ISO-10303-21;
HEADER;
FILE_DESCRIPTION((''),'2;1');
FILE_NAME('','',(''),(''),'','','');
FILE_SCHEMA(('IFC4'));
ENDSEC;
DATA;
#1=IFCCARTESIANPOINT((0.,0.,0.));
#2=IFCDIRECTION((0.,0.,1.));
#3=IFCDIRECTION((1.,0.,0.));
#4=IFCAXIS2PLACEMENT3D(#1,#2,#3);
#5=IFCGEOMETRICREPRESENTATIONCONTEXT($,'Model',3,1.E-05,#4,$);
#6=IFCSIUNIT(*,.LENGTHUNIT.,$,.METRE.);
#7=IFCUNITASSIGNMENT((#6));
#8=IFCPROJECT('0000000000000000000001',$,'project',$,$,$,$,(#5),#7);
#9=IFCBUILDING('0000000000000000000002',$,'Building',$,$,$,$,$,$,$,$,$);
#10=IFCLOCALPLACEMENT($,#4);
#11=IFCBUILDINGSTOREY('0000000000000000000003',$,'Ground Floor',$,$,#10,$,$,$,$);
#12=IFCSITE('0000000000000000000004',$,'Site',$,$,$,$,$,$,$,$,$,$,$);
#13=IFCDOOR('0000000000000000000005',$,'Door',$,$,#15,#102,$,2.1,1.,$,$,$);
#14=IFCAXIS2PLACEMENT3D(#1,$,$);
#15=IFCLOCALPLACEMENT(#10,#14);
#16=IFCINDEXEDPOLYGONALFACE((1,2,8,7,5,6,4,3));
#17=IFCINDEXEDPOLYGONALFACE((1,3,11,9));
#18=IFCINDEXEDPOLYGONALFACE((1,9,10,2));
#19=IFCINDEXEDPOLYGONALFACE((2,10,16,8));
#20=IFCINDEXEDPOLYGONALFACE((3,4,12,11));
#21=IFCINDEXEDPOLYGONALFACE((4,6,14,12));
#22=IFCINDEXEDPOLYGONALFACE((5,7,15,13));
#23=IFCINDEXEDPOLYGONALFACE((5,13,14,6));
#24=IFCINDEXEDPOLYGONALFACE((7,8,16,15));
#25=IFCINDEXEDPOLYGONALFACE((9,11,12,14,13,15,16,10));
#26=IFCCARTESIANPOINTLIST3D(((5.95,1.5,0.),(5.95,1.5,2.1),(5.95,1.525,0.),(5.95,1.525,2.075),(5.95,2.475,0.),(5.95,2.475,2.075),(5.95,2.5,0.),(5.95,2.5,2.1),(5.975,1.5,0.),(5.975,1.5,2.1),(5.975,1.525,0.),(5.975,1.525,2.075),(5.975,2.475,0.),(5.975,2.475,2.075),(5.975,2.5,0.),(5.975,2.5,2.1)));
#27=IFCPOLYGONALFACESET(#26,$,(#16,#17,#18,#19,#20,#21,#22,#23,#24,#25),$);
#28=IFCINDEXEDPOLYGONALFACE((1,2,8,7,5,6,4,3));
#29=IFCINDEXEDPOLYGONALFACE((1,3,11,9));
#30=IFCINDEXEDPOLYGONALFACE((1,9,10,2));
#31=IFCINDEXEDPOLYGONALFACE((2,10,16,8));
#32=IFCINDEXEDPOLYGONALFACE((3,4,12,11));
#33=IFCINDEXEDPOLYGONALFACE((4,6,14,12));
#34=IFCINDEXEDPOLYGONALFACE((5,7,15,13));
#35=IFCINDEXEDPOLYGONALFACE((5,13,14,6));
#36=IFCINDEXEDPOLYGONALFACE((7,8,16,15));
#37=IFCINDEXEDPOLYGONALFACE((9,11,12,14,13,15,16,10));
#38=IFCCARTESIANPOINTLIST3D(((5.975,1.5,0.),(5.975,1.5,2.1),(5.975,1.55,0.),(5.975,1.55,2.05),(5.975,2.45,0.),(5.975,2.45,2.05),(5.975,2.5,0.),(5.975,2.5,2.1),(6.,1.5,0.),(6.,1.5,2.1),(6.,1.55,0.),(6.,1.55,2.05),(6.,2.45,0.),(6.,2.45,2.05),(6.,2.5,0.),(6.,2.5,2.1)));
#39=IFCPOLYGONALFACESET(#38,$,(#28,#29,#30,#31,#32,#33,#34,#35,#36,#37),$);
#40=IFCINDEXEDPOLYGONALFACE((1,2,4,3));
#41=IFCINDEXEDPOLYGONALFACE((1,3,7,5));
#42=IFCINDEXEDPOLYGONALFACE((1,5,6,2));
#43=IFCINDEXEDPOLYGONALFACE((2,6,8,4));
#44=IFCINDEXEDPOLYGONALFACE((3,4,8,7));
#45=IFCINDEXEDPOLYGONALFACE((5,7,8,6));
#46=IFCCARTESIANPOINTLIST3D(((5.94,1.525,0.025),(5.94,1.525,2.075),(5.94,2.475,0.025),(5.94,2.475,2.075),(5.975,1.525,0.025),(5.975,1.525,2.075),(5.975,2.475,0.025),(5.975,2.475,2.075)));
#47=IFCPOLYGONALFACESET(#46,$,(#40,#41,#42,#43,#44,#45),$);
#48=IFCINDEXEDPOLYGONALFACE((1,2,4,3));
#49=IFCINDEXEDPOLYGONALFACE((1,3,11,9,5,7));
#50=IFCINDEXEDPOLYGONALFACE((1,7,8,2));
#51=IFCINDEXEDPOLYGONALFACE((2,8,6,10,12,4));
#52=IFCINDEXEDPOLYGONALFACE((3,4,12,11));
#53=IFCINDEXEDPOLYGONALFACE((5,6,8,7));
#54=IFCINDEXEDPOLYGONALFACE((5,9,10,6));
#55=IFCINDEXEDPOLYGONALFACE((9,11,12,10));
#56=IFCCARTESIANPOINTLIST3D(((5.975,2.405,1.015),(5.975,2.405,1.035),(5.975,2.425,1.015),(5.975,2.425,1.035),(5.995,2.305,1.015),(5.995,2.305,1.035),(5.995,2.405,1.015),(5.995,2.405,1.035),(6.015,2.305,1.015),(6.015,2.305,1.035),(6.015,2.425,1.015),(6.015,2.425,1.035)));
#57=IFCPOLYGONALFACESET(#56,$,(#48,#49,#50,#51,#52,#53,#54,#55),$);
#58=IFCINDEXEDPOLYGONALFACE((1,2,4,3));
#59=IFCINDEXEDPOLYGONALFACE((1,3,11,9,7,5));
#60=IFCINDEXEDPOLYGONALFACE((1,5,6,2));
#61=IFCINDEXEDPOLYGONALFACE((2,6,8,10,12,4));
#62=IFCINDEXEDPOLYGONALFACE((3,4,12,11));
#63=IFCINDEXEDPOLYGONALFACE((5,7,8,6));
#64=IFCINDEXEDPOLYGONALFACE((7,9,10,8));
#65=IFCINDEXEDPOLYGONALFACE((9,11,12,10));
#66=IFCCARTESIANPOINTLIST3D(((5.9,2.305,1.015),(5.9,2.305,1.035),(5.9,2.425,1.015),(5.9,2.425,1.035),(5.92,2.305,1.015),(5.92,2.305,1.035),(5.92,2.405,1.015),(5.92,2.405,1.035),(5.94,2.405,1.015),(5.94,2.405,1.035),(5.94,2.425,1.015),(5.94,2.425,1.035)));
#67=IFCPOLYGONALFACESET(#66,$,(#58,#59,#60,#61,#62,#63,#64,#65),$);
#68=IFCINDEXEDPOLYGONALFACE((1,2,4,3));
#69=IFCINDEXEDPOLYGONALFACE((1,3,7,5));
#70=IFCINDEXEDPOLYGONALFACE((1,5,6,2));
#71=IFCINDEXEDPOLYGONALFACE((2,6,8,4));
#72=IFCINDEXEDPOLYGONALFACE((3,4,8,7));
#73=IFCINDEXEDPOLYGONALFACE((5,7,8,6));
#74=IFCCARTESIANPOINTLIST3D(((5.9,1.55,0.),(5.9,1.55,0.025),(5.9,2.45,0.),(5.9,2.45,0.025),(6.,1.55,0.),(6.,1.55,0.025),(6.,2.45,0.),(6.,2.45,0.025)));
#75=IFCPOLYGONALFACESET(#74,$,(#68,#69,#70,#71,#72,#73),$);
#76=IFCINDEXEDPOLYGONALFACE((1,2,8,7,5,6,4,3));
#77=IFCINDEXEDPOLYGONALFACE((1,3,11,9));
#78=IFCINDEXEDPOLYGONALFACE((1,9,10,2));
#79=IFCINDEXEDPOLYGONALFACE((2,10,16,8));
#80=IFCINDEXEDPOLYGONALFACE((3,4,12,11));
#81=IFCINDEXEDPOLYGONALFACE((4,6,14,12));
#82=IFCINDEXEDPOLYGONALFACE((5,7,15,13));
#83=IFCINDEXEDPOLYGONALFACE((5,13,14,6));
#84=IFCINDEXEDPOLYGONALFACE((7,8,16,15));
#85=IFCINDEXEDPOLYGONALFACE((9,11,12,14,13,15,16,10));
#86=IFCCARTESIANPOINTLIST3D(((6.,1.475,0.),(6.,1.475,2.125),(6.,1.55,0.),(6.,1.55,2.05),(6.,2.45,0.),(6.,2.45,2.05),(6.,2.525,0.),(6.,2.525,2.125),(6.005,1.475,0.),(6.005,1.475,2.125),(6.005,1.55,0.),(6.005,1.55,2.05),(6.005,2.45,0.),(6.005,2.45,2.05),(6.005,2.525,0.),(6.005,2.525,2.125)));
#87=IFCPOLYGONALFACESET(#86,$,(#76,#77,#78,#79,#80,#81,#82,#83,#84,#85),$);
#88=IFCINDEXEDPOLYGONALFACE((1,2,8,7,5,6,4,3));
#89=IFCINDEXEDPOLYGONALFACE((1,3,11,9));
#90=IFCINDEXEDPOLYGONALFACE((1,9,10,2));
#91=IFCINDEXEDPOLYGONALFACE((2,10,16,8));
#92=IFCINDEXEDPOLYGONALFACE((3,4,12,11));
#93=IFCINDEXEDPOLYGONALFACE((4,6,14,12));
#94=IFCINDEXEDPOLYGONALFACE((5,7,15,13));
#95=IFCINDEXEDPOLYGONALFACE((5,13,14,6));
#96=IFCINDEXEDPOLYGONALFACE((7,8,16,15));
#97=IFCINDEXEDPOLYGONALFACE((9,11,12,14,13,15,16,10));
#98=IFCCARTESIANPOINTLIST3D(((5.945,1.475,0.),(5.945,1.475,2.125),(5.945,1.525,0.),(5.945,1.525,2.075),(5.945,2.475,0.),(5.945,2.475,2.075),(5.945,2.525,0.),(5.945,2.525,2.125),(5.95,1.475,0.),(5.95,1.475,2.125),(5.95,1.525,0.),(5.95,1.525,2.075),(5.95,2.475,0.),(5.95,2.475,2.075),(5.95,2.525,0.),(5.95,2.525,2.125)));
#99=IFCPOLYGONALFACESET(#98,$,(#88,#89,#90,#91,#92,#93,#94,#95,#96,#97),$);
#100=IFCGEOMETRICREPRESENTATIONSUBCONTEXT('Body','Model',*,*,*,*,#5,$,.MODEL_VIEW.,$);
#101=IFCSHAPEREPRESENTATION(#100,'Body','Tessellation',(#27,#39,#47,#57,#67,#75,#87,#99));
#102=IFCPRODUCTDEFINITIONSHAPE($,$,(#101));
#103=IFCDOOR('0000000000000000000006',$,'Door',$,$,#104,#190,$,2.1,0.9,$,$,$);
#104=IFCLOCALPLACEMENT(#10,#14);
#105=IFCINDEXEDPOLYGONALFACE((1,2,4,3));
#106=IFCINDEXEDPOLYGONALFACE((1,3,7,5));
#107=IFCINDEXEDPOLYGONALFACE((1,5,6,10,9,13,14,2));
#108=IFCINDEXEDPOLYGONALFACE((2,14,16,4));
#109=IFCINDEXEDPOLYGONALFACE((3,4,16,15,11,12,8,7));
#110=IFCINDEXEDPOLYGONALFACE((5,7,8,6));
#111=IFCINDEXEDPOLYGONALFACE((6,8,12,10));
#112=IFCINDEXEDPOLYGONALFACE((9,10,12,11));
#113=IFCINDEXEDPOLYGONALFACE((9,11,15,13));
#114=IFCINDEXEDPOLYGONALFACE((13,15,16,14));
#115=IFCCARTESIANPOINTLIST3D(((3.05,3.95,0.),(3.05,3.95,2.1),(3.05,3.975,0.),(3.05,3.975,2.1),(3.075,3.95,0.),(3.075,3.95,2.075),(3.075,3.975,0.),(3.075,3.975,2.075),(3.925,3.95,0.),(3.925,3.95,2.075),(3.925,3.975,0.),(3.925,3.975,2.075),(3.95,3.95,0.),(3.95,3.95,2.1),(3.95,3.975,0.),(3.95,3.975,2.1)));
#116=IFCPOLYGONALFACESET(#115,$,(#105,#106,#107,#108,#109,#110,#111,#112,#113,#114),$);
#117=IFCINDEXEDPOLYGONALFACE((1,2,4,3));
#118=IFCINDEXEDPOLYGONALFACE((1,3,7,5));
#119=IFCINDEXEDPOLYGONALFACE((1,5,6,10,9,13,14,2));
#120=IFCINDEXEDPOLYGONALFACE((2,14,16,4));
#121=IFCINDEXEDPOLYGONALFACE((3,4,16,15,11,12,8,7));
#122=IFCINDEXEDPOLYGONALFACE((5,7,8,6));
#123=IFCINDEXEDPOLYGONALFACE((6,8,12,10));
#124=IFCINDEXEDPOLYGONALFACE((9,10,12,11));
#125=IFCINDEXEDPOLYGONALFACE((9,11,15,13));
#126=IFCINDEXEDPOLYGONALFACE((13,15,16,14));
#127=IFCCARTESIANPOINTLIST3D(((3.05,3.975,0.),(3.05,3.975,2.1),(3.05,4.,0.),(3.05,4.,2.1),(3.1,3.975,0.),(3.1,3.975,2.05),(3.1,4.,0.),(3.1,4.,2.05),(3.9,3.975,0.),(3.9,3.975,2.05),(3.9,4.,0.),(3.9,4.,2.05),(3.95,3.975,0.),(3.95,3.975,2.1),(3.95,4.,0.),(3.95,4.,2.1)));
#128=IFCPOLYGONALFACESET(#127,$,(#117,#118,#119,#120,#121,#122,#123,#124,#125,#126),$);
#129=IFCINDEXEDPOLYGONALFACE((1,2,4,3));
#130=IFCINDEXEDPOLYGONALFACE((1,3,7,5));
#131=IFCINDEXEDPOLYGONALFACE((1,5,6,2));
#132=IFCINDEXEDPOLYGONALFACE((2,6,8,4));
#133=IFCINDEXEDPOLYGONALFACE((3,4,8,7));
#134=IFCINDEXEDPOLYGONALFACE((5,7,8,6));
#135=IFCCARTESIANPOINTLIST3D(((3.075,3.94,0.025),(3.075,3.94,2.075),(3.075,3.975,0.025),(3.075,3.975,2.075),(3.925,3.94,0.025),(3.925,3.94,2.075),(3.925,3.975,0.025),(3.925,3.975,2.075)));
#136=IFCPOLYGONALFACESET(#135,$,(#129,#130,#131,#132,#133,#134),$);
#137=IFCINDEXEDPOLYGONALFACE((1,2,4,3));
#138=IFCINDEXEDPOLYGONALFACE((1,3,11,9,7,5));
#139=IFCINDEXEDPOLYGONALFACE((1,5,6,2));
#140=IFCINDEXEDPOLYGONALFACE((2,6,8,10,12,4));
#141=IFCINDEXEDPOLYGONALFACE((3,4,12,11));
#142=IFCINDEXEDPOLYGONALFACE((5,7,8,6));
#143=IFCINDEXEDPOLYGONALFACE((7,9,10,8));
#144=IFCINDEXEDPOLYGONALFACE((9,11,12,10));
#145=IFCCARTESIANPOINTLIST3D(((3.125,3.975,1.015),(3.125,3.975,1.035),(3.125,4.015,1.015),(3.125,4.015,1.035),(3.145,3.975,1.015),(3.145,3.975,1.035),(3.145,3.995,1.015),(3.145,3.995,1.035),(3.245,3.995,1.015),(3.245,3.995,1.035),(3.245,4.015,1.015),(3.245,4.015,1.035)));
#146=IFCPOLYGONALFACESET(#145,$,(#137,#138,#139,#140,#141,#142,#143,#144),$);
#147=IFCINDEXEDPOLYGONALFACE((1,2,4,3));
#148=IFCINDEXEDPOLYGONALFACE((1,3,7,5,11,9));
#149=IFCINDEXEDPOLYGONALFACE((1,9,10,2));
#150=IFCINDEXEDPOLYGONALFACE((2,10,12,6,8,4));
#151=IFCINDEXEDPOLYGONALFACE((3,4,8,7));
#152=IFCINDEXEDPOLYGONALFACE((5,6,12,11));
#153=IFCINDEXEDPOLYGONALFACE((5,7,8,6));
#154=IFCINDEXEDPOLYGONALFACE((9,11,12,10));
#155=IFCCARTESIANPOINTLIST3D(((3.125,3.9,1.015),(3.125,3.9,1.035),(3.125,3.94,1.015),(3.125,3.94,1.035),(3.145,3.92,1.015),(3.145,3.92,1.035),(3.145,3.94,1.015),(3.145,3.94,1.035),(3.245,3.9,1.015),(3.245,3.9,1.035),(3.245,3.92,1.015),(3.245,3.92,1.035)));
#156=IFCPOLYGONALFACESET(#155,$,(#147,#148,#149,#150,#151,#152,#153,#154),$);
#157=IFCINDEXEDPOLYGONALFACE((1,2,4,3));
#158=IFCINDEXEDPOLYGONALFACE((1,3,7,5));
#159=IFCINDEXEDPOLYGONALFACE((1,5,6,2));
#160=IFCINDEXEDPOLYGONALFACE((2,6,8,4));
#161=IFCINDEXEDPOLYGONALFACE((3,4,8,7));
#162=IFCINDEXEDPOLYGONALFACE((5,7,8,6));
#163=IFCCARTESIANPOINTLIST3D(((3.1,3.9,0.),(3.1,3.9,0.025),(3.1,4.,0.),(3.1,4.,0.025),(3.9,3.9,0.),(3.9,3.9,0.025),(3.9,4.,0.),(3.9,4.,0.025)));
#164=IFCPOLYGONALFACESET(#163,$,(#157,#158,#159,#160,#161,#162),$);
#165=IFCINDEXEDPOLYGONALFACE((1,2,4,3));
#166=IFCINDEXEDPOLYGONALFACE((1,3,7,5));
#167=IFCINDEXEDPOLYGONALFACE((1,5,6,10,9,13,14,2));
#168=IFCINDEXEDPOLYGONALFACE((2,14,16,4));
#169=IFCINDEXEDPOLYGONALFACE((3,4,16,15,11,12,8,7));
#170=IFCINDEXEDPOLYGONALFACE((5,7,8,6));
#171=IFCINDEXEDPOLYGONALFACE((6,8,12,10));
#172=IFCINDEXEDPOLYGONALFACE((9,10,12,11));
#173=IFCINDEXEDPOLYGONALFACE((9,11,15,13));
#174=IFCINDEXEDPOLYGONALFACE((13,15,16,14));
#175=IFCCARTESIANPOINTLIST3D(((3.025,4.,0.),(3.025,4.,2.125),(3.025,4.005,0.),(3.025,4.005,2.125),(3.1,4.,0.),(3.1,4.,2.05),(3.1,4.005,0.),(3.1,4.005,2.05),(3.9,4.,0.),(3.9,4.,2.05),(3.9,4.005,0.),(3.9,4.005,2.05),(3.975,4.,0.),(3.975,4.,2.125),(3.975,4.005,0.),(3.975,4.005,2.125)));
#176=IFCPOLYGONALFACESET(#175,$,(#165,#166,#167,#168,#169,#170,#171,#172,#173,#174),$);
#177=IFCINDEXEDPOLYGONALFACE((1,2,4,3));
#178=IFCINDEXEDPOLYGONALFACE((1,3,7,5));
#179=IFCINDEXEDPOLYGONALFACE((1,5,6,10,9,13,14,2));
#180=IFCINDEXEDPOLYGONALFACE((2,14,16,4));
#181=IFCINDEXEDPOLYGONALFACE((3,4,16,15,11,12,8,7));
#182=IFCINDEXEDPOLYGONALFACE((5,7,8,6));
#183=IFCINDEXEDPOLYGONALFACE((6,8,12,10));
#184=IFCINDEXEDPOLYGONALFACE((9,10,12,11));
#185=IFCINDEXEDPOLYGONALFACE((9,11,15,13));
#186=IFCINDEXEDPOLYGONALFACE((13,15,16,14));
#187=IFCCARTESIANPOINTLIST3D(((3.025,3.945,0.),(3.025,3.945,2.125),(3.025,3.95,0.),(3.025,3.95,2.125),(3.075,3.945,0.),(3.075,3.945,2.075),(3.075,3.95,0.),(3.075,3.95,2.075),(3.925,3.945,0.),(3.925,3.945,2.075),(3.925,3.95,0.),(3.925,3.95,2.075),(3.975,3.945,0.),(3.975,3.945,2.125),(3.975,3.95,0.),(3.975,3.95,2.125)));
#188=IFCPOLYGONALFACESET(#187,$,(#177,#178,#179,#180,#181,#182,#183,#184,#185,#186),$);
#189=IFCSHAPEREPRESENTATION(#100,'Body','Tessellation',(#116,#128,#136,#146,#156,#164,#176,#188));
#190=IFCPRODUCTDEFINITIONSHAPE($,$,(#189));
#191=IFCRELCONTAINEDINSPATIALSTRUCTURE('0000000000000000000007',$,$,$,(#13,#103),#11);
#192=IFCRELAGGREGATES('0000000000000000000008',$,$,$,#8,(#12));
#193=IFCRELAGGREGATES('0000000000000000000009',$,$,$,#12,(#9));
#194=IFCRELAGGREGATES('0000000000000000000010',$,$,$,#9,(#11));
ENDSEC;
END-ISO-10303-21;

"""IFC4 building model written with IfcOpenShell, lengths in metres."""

from ifc_helpers import new_model, si_unit, frame, origin_with_axes, place, context, subcontext, project, spatial, line, indexed_curve, outline, extrude, element, save


model = new_model("IFC4")

# Units and contexts
model_context = context("Model", 3, precision=1e-05, world=origin_with_axes())
body_context = subcontext(model_context, "Body", "Model", "MODEL_VIEW")
ifc_project = project(units=[si_unit("LENGTHUNIT", "METRE")], contexts=[model_context])

# Site, building, storey
site = spatial("IfcSite", under=ifc_project, Name="Site")
building = spatial("IfcBuilding", under=site, Name="Building")
storey_placement = place(None, origin_with_axes())
storey = spatial("IfcBuildingStorey", under=building, at=storey_placement, Name="Ground Floor")

# Doors
door_1_placement = place(storey_placement, frame((6.0, 1.5, 0.0), z_axis=(0.0, 0.0, 1.0), x_axis=(0.0, 1.0, 0.0)))
element("IfcDoor", 1, at=door_1_placement, inside=storey, Name="Door", OverallHeight=2.1, OverallWidth=1.0, context=body_context, shape_type="SweptSolid", body=[
    extrude(outline(indexed_curve([(0.0, 0.0), (0.0, 2.1), (1.0, 2.1), (1.0, 0.0), (0.975, 0.0), (0.975, 2.075), (0.025, 2.075), (0.025, 0.0)], segments=[line(1, 2, 3, 4, 5, 6, 7, 8, 1)])), frame((0.0, 0.025, 0.0), z_axis=(0.0, -1.0, 0.0), x_axis=(1.0, 0.0, 0.0)), (0.0, 0.0, -1.0), 0.025),
    extrude(outline(indexed_curve([(0.0, 0.0), (0.0, 2.1), (1.0, 2.1), (1.0, 0.0), (0.95, 0.0), (0.95, 2.05), (0.05, 2.05), (0.05, 0.0)], segments=[line(1, 2, 3, 4, 5, 6, 7, 8, 1)])), frame((0.0, 0.0, 0.0), z_axis=(0.0, -1.0, 0.0), x_axis=(1.0, 0.0, 0.0)), (0.0, 0.0, -1.0), 0.025),
    extrude(outline(indexed_curve([(0.0, 0.0), (0.95, 0.0), (0.95, 0.035), (0.0, 0.035)], segments=[line(1, 2, 3, 4, 1)])), frame((0.025, 0.025, 0.025), z_axis=(0.0, 0.0, 1.0), x_axis=(1.0, 0.0, 0.0)), (0.0, 0.0, 1.0), 2.05),
    extrude(outline(indexed_curve([(0.0, 0.0), (0.0, -0.04), (-0.12, -0.04), (-0.12, -0.02), (-0.02, -0.02), (-0.02, 0.0)], segments=[line(1, 2, 3, 4, 5, 6, 1)])), frame((0.925, 0.025, 1.015), z_axis=(0.0, 0.0, 1.0), x_axis=(1.0, 0.0, 0.0)), (0.0, 0.0, 1.0), 0.02),
    extrude(outline(indexed_curve([(0.0, 0.0), (0.0, 0.04), (-0.12, 0.04), (-0.12, 0.02), (-0.02, 0.02), (-0.02, 0.0)], segments=[line(1, 2, 3, 4, 5, 6, 1)])), frame((0.925, 0.06, 1.015), z_axis=(0.0, 0.0, 1.0), x_axis=(1.0, 0.0, 0.0)), (0.0, 0.0, 1.0), 0.02),
    extrude(outline(indexed_curve([(0.0, 0.0), (0.9, 0.0), (0.9, 0.1), (0.0, 0.1)], segments=[line(1, 2, 3, 4, 1)])), frame((0.05, 0.0, 0.0), z_axis=(0.0, 0.0, 1.0), x_axis=(1.0, 0.0, 0.0)), (0.0, 0.0, 1.0), 0.025),
    extrude(outline(indexed_curve([(0.0, 0.0), (0.0, 2.125), (1.05, 2.125), (1.05, 0.0), (0.975, 0.0), (0.975, 2.05), (0.075, 2.05), (0.075, 0.0)], segments=[line(1, 2, 3, 4, 5, 6, 7, 8, 1)])), frame((-0.025, -0.005, 0.0), z_axis=(0.0, -1.0, 0.0), x_axis=(1.0, 0.0, 0.0)), (0.0, 0.0, -1.0), 0.005),
    extrude(outline(indexed_curve([(0.0, 0.0), (0.0, 2.125), (1.05, 2.125), (1.05, 0.0), (1.0, 0.0), (1.0, 2.075), (0.05, 2.075), (0.05, 0.0)], segments=[line(1, 2, 3, 4, 5, 6, 7, 8, 1)])), frame((-0.025, 0.05, 0.0), z_axis=(0.0, -1.0, 0.0), x_axis=(1.0, 0.0, 0.0)), (0.0, 0.0, -1.0), 0.005),
])
door_2_placement = place(storey_placement, frame((3.95, 4.0, 0.0), z_axis=(0.0, 0.0, 1.0), x_axis=(-1.0, 0.0, 0.0)))
element("IfcDoor", 2, at=door_2_placement, inside=storey, Name="Door", OverallHeight=2.1, OverallWidth=0.9, context=body_context, shape_type="SweptSolid", body=[
    extrude(outline(indexed_curve([(0.0, 0.0), (0.0, 2.1), (0.9, 2.1), (0.9, 0.0), (0.875, 0.0), (0.875, 2.075), (0.025, 2.075), (0.025, 0.0)], segments=[line(1, 2, 3, 4, 5, 6, 7, 8, 1)])), frame((0.0, 0.025, 0.0), z_axis=(0.0, -1.0, 0.0), x_axis=(1.0, 0.0, 0.0)), (0.0, 0.0, -1.0), 0.025),
    extrude(outline(indexed_curve([(0.0, 0.0), (0.0, 2.1), (0.9, 2.1), (0.9, 0.0), (0.85, 0.0), (0.85, 2.05), (0.05, 2.05), (0.05, 0.0)], segments=[line(1, 2, 3, 4, 5, 6, 7, 8, 1)])), frame((0.0, 0.0, 0.0), z_axis=(0.0, -1.0, 0.0), x_axis=(1.0, 0.0, 0.0)), (0.0, 0.0, -1.0), 0.025),
    extrude(outline(indexed_curve([(0.0, 0.0), (0.85, 0.0), (0.85, 0.035), (0.0, 0.035)], segments=[line(1, 2, 3, 4, 1)])), frame((0.025, 0.025, 0.025), z_axis=(0.0, 0.0, 1.0), x_axis=(1.0, 0.0, 0.0)), (0.0, 0.0, 1.0), 2.05),
    extrude(outline(indexed_curve([(0.0, 0.0), (0.0, -0.04), (-0.12, -0.04), (-0.12, -0.02), (-0.02, -0.02), (-0.02, 0.0)], segments=[line(1, 2, 3, 4, 5, 6, 1)])), frame((0.825, 0.025, 1.015), z_axis=(0.0, 0.0, 1.0), x_axis=(1.0, 0.0, 0.0)), (0.0, 0.0, 1.0), 0.02),
    extrude(outline(indexed_curve([(0.0, 0.0), (0.0, 0.04), (-0.12, 0.04), (-0.12, 0.02), (-0.02, 0.02), (-0.02, 0.0)], segments=[line(1, 2, 3, 4, 5, 6, 1)])), frame((0.825, 0.06, 1.015), z_axis=(0.0, 0.0, 1.0), x_axis=(1.0, 0.0, 0.0)), (0.0, 0.0, 1.0), 0.02),
    extrude(outline(indexed_curve([(0.0, 0.0), (0.8, 0.0), (0.8, 0.1), (0.0, 0.1)], segments=[line(1, 2, 3, 4, 1)])), frame((0.05, 0.0, 0.0), z_axis=(0.0, 0.0, 1.0), x_axis=(1.0, 0.0, 0.0)), (0.0, 0.0, 1.0), 0.025),
    extrude(outline(indexed_curve([(0.0, 0.0), (0.0, 2.125), (0.95, 2.125), (0.95, 0.0), (0.875, 0.0), (0.875, 2.05), (0.075, 2.05), (0.075, 0.0)], segments=[line(1, 2, 3, 4, 5, 6, 7, 8, 1)])), frame((-0.025, -0.005, 0.0), z_axis=(0.0, -1.0, 0.0), x_axis=(1.0, 0.0, 0.0)), (0.0, 0.0, -1.0), 0.005),
    extrude(outline(indexed_curve([(0.0, 0.0), (0.0, 2.125), (0.95, 2.125), (0.95, 0.0), (0.9, 0.0), (0.9, 2.075), (0.05, 2.075), (0.05, 0.0)], segments=[line(1, 2, 3, 4, 5, 6, 7, 8, 1)])), frame((-0.025, 0.05, 0.0), z_axis=(0.0, -1.0, 0.0), x_axis=(1.0, 0.0, 0.0)), (0.0, 0.0, -1.0), 0.005),
])

save(model, "model.ifc")
